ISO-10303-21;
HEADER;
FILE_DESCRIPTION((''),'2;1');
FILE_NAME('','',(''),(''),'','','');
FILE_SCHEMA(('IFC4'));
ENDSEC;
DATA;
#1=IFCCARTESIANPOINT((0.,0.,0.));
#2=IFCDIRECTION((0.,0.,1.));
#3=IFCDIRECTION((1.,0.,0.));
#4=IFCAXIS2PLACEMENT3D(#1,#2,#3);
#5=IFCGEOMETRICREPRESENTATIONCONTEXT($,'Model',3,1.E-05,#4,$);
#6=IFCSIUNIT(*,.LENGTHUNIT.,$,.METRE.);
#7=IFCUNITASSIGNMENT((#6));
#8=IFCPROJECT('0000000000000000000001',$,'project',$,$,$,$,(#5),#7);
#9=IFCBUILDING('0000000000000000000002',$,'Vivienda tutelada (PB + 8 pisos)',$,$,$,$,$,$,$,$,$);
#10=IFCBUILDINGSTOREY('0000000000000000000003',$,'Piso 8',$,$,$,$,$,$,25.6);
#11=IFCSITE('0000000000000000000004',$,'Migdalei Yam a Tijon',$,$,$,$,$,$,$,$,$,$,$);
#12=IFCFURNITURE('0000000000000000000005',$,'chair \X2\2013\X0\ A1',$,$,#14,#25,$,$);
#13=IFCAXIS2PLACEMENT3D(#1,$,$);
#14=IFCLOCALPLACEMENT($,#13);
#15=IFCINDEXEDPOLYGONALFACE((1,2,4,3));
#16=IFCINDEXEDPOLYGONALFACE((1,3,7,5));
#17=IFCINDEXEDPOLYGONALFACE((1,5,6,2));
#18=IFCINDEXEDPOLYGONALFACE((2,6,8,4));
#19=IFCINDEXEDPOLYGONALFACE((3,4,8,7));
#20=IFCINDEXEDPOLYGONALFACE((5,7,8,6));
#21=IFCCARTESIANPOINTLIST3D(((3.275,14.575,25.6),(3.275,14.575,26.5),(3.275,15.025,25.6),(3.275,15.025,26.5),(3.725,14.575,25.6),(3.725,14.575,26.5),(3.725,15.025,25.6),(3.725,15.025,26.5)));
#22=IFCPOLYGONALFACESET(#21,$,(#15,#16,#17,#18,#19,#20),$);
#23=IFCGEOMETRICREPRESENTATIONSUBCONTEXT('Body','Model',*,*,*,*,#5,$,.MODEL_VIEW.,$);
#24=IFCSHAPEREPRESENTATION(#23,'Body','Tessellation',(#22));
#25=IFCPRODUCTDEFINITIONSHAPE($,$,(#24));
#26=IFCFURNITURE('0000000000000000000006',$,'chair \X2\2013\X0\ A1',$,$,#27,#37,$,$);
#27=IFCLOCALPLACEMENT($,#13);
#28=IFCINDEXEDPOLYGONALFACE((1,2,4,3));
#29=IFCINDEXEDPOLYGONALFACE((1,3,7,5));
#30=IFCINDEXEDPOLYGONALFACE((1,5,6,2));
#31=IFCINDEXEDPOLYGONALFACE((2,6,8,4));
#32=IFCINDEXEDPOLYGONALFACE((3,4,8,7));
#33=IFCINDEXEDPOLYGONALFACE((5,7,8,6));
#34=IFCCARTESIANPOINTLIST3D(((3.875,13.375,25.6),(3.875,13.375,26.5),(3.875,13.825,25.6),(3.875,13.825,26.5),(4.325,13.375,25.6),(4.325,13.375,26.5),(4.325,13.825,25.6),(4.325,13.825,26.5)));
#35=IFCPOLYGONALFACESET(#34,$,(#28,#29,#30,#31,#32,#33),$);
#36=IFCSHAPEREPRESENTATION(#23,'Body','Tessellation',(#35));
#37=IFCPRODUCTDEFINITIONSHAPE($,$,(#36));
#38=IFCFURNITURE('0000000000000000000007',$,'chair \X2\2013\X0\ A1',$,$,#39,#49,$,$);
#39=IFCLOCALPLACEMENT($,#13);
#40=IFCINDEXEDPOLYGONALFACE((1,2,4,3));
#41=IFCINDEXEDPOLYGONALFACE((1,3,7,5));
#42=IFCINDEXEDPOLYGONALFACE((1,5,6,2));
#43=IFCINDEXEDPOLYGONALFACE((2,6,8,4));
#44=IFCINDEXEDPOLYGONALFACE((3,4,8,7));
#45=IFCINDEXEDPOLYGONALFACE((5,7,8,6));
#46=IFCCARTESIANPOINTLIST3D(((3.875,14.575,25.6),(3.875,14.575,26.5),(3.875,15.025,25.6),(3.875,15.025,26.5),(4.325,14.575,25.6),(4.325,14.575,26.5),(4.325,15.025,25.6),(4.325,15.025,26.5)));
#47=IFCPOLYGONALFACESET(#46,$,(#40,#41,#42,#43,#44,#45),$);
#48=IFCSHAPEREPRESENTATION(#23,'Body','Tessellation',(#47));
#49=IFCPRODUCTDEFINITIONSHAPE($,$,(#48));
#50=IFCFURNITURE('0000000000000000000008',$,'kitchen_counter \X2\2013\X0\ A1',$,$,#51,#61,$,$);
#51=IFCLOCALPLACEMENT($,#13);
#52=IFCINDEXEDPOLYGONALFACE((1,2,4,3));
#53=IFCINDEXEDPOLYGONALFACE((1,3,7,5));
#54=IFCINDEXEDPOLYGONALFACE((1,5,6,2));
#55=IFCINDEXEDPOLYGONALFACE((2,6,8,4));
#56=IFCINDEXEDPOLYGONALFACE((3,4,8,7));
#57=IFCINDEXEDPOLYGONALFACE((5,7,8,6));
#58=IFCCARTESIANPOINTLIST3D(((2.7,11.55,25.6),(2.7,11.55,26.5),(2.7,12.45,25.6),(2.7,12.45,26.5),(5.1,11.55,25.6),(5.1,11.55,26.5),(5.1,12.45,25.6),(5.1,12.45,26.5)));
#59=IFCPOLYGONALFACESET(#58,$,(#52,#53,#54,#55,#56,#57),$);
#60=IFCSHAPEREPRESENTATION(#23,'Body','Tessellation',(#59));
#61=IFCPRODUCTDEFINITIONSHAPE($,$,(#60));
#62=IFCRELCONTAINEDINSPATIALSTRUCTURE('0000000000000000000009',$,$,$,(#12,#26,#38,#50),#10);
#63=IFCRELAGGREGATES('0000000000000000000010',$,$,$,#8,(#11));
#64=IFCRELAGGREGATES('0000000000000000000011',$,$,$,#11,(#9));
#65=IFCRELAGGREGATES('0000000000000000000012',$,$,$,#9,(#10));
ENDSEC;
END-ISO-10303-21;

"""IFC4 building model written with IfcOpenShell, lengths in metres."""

from ifc_helpers import new_model, si_unit, frame, origin_with_axes, context, subcontext, project, spatial, line, indexed_curve, outline, extrude, element, save


model = new_model("IFC4")

# Units and contexts
model_context = context("Model", 3, precision=1e-05, world=origin_with_axes())
body_context = subcontext(model_context, "Body", "Model", "MODEL_VIEW")
ifc_project = project(units=[si_unit("LENGTHUNIT", "METRE")], contexts=[model_context])

# Site, building, storey
site = spatial("IfcSite", under=ifc_project, Name="Migdalei Yam a Tijon")
building = spatial("IfcBuilding", under=site, Name="Vivienda tutelada (PB + 8 pisos)")
storey = spatial("IfcBuildingStorey", under=building, Name="Piso 8", Elevation=25.6)

# Furniture
element("IfcFurniture", 1, inside=storey, Name="chair – A1", context=body_context, shape_type="SweptSolid", body=[
    extrude(outline(indexed_curve([(0.0, 0.0), (0.45, 0.0), (0.45, 0.45), (0.0, 0.45)], segments=[line(1, 2, 3, 4, 1)])), frame((3.275, 14.575, 25.6), z_axis=(0.0, 0.0, 1.0), x_axis=(1.0, 0.0, 0.0)), (0.0, 0.0, 1.0), 0.9),
])
element("IfcFurniture", 2, inside=storey, Name="chair – A1", context=body_context, shape_type="SweptSolid", body=[
    extrude(outline(indexed_curve([(0.0, 0.0), (0.45, 0.0), (0.45, 0.45), (0.0, 0.45)], segments=[line(1, 2, 3, 4, 1)])), frame((3.875, 13.375, 25.6), z_axis=(0.0, 0.0, 1.0), x_axis=(1.0, 0.0, 0.0)), (0.0, 0.0, 1.0), 0.9),
])
element("IfcFurniture", 3, inside=storey, Name="chair – A1", context=body_context, shape_type="SweptSolid", body=[
    extrude(outline(indexed_curve([(0.0, 0.0), (0.45, 0.0), (0.45, 0.45), (0.0, 0.45)], segments=[line(1, 2, 3, 4, 1)])), frame((3.875, 14.575, 25.6), z_axis=(0.0, 0.0, 1.0), x_axis=(1.0, 0.0, 0.0)), (0.0, 0.0, 1.0), 0.9),
])
element("IfcFurniture", 4, inside=storey, Name="kitchen_counter – A1", context=body_context, shape_type="SweptSolid", body=[
    extrude(outline(indexed_curve([(0.0, 0.0), (2.4, 0.0), (2.4, 0.9), (0.0, 0.9)], segments=[line(1, 2, 3, 4, 1)])), frame((2.7, 11.55, 25.6), z_axis=(0.0, 0.0, 1.0), x_axis=(1.0, 0.0, 0.0)), (0.0, 0.0, 1.0), 0.9),
])

save(model, "model.ifc")
